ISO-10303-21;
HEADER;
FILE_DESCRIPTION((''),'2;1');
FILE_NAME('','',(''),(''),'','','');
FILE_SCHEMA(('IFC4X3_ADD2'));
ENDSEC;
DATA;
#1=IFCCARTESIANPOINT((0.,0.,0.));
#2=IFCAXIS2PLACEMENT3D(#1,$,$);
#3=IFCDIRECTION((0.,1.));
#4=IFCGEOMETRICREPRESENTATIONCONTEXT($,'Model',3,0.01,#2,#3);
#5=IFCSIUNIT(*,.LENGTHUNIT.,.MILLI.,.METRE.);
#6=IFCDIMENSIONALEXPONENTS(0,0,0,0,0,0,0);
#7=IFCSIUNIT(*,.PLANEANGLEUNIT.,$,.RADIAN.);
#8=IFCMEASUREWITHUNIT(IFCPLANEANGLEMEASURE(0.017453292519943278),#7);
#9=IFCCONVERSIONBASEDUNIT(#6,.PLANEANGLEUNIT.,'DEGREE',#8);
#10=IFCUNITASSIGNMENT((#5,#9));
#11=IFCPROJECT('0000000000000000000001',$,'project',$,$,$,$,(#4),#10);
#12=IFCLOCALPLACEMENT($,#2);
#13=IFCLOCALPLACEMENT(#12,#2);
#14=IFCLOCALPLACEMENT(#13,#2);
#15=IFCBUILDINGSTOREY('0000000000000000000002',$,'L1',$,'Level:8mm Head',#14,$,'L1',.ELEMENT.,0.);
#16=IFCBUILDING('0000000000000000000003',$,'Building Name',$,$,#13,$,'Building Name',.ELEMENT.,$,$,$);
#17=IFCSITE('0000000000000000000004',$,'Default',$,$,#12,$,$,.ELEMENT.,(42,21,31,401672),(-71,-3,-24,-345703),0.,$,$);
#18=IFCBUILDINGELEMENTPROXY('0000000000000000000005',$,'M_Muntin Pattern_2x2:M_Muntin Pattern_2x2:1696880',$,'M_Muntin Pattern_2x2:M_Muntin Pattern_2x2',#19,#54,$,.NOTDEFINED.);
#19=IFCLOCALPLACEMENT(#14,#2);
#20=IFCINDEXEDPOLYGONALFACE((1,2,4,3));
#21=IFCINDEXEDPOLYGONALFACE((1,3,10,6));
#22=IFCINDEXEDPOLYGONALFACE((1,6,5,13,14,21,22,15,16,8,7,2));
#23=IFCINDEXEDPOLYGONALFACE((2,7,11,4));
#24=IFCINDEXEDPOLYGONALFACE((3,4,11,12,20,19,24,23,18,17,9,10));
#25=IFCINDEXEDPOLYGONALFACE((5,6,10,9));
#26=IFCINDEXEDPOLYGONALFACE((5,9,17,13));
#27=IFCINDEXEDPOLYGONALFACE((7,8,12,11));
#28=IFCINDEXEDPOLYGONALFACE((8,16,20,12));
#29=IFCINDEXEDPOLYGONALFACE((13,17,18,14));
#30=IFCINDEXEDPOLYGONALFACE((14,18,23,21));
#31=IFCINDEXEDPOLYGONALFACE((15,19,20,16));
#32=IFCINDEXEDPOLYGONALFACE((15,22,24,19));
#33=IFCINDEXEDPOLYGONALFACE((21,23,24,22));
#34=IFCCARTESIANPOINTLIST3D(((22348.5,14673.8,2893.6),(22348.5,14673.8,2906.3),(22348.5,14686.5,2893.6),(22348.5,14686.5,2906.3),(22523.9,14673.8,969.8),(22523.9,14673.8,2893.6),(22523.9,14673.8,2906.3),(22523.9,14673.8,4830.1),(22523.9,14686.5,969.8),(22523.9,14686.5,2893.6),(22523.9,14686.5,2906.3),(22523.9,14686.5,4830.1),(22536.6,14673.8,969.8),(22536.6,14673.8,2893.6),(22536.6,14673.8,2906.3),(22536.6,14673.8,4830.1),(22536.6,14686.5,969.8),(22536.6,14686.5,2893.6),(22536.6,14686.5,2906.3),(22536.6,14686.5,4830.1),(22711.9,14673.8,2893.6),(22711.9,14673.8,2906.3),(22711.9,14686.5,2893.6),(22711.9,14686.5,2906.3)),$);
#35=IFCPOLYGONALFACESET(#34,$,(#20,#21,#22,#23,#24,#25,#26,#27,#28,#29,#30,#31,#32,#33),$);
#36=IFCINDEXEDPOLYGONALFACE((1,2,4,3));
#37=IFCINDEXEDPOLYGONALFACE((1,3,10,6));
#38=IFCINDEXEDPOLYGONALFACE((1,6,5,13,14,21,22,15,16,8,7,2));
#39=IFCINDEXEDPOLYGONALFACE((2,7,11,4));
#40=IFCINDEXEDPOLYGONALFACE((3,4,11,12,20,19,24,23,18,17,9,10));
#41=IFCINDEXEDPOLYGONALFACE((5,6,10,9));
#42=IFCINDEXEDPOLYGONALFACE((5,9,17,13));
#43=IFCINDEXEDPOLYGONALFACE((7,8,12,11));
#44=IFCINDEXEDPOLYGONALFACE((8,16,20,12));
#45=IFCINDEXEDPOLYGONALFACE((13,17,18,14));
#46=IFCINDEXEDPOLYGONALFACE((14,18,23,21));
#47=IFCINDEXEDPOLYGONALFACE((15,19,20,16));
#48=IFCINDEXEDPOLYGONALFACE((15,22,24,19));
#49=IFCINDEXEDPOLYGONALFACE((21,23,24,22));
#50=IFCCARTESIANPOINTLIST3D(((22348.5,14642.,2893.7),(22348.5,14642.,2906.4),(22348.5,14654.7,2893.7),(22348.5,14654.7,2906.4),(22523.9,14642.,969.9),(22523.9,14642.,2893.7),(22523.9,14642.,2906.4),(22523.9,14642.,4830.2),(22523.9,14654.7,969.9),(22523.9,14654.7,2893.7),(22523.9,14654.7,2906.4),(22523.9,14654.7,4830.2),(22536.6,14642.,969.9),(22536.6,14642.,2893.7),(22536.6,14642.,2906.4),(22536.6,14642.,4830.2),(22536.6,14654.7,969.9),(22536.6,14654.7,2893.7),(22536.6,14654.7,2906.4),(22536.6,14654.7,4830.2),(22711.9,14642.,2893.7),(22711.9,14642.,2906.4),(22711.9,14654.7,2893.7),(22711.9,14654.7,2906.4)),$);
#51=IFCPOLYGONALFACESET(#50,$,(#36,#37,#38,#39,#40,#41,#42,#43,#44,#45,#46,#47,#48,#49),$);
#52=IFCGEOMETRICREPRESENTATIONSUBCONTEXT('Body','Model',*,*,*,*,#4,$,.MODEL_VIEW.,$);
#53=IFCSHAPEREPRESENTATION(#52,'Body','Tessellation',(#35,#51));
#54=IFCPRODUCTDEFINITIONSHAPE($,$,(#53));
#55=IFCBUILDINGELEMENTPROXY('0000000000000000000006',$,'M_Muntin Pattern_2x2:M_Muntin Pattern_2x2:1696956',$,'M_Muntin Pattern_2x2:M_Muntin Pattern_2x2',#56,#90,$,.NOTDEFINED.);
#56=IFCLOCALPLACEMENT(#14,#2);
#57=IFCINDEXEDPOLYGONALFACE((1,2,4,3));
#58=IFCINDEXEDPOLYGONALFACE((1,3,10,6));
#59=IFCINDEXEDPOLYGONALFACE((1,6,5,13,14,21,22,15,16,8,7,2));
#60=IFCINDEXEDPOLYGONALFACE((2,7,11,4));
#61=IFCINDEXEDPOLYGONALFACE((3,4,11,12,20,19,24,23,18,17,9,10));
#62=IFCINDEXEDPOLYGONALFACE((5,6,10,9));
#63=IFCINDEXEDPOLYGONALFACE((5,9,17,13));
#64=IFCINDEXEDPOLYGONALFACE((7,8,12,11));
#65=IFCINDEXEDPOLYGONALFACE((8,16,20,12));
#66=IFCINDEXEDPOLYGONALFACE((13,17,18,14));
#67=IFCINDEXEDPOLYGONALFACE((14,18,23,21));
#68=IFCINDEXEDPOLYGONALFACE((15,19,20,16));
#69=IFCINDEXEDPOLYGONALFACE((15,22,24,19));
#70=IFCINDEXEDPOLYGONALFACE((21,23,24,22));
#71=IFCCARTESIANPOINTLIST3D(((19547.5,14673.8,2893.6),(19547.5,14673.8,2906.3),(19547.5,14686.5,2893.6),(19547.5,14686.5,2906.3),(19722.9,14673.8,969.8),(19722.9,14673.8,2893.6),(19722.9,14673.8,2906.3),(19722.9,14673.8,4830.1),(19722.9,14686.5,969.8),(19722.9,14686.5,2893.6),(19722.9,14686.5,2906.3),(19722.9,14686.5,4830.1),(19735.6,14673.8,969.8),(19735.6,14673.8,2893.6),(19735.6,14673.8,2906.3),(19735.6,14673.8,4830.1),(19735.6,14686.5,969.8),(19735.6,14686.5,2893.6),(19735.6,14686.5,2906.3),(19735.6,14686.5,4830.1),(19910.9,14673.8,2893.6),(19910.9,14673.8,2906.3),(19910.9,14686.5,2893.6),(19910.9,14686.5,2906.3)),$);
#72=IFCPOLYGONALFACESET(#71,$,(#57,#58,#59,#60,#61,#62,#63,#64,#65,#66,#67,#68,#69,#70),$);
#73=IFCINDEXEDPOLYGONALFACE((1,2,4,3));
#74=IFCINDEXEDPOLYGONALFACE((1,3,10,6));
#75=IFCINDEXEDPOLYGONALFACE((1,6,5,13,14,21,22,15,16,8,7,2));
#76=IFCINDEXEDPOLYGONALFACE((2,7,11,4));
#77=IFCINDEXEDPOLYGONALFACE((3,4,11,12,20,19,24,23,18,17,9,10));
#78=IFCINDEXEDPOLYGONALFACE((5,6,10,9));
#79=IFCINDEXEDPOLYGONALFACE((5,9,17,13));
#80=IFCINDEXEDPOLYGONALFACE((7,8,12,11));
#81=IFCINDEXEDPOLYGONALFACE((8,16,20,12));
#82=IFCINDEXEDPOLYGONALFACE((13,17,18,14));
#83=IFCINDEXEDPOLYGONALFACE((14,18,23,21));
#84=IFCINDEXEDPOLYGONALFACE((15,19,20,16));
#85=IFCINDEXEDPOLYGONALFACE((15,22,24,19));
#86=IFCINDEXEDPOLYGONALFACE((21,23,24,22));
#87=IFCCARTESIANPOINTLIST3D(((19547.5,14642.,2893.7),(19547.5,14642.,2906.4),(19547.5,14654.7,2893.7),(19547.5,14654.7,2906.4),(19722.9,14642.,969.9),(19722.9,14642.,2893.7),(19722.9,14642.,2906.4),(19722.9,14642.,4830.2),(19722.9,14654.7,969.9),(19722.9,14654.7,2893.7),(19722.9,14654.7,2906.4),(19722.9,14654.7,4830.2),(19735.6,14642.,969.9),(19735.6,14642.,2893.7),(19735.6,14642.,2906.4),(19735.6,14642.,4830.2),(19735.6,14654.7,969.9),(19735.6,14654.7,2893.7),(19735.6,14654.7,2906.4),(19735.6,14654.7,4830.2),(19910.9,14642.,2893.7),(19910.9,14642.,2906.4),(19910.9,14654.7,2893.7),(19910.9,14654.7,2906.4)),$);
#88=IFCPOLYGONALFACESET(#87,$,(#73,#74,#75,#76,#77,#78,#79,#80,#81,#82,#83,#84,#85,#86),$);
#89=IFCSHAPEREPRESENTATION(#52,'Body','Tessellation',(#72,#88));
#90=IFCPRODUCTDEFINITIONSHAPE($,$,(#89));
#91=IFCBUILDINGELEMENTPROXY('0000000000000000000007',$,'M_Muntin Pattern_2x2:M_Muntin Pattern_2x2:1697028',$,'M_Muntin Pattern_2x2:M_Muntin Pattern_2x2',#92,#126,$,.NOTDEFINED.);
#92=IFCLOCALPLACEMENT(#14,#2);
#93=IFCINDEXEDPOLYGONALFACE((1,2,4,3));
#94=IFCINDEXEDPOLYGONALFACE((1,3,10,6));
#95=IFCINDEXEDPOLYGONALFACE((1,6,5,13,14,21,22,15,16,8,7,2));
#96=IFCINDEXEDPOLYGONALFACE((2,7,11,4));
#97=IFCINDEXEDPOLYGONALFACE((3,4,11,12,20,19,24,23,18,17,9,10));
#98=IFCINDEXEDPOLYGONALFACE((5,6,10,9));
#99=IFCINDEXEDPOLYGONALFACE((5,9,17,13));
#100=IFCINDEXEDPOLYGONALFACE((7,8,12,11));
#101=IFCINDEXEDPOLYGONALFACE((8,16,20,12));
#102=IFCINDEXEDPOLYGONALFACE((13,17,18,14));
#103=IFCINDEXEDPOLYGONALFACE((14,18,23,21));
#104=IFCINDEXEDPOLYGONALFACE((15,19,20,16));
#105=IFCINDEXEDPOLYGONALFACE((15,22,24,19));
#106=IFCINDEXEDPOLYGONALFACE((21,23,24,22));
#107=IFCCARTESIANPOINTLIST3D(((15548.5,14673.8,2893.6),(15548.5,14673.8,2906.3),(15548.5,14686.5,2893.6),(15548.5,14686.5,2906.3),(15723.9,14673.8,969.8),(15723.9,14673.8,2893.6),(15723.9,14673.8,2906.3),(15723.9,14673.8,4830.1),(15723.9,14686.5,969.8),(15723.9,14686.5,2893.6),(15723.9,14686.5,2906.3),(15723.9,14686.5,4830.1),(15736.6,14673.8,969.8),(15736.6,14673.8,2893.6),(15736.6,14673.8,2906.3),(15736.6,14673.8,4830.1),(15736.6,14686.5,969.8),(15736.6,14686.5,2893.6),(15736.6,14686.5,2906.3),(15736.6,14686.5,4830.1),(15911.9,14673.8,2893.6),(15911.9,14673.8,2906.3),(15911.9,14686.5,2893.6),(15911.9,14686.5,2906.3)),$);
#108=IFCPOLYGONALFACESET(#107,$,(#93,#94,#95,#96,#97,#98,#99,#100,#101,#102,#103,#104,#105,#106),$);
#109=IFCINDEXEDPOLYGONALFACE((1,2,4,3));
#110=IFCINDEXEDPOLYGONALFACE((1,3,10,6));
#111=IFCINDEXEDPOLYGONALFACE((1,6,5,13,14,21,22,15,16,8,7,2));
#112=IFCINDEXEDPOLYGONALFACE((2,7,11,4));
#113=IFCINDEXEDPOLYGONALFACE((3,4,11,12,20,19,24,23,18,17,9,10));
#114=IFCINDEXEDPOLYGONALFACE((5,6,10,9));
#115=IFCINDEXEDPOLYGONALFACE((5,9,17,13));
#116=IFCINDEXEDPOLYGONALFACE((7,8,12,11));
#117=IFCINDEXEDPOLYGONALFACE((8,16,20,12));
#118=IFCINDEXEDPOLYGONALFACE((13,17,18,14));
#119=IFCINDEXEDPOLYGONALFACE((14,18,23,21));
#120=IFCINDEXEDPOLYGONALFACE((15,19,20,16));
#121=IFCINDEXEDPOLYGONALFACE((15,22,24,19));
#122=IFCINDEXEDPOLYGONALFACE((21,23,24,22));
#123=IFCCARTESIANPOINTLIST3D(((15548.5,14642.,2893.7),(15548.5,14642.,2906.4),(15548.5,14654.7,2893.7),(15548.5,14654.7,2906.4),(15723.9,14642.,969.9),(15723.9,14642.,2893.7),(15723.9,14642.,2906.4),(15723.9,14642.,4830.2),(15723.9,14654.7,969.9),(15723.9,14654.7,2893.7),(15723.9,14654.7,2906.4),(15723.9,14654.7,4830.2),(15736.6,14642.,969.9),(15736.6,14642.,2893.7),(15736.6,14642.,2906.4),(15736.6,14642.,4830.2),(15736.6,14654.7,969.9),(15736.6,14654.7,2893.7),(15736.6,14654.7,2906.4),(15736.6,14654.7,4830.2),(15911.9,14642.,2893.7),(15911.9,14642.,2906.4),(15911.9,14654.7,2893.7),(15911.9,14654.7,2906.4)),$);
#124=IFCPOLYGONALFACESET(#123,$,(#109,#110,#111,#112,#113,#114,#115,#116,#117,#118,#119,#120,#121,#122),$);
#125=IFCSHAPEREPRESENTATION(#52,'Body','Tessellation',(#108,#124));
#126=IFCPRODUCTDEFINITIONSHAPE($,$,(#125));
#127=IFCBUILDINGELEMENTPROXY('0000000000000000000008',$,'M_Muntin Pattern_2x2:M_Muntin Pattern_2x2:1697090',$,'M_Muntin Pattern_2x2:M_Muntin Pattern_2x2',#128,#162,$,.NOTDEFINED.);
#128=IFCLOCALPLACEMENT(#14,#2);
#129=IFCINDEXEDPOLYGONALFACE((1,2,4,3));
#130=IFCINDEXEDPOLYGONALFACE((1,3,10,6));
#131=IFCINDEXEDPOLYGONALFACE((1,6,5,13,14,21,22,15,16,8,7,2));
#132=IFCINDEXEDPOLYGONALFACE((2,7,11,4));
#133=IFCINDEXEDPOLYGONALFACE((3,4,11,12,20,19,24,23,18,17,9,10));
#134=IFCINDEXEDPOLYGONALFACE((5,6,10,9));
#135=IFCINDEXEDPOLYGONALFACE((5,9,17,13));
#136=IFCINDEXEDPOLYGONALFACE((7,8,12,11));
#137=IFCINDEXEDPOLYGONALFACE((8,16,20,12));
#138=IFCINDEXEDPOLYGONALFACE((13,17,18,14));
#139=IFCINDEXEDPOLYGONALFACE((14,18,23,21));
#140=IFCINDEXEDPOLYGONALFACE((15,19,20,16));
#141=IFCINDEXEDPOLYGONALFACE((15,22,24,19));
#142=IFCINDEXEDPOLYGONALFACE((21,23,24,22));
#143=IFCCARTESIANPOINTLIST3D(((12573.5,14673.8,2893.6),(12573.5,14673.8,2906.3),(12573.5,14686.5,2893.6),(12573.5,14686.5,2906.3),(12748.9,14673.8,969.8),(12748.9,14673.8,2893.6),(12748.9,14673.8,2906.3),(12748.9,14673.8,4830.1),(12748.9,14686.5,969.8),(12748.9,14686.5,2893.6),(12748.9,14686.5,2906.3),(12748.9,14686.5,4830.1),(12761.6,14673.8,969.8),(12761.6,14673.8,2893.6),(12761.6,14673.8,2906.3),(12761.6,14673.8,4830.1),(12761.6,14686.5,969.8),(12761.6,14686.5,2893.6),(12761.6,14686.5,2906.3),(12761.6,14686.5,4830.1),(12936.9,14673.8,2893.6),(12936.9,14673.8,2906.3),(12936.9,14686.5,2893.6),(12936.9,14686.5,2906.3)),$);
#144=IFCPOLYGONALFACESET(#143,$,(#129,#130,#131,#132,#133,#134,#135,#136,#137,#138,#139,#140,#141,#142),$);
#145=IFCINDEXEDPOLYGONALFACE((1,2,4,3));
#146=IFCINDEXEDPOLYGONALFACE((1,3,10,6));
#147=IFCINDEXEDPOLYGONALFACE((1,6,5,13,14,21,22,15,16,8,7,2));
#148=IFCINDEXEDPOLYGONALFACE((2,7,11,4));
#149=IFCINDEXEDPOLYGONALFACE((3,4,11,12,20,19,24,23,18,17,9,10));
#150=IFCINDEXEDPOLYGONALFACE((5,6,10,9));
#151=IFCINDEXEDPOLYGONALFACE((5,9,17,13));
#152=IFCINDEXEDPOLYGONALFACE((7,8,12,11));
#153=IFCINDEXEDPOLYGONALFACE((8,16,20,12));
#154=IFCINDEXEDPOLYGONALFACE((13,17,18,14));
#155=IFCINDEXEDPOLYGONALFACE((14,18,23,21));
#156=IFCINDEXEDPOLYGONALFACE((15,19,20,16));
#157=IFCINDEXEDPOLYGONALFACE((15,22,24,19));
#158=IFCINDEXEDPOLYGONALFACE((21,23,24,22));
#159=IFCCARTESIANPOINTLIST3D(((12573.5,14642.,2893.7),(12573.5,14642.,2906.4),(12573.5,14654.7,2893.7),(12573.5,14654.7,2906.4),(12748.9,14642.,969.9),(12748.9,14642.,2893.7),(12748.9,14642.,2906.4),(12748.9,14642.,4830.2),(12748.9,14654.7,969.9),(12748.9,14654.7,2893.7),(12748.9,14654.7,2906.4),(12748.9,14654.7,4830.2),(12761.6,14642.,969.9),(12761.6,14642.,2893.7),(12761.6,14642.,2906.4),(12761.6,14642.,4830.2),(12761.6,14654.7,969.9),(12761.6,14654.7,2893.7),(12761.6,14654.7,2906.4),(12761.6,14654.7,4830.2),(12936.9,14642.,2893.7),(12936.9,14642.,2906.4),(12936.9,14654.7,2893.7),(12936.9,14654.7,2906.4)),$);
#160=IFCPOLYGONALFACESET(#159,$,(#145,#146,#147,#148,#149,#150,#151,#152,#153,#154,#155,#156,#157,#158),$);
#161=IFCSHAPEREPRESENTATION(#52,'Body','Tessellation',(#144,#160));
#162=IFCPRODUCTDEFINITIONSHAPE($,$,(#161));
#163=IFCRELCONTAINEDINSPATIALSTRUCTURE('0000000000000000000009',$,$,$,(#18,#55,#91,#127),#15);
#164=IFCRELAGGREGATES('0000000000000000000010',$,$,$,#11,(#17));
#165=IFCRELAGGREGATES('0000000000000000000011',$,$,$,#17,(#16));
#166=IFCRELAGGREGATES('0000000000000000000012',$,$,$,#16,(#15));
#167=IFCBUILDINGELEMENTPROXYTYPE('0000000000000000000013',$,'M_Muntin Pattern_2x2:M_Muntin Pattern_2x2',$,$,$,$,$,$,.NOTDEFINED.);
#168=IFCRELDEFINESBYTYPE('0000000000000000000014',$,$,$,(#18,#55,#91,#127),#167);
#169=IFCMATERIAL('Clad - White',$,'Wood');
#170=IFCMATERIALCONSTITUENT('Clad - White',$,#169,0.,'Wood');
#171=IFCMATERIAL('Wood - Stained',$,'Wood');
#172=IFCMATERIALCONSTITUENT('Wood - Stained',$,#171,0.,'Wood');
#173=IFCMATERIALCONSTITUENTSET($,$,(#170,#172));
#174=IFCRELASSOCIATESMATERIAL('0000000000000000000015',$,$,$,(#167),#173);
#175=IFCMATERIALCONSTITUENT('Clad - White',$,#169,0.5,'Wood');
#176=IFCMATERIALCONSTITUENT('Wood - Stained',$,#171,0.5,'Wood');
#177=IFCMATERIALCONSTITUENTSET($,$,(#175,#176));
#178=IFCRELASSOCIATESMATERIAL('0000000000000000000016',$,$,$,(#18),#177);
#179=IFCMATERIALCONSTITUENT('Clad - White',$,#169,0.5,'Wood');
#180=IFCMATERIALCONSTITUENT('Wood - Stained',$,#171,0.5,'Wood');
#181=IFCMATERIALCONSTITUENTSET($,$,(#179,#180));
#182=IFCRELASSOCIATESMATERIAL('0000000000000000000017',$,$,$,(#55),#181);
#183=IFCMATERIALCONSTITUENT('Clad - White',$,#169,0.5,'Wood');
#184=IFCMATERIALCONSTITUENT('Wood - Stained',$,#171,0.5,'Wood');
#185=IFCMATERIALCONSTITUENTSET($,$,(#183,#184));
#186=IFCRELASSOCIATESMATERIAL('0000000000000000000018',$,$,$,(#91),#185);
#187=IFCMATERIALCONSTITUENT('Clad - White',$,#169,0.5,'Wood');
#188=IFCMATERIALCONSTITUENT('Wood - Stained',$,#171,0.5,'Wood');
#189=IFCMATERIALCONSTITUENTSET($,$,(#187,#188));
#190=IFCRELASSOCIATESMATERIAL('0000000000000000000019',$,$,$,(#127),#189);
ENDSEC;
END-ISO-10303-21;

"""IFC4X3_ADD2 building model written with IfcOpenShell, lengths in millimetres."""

from ifc_helpers import new_model, entity, si_unit, converted_unit, direction, frame, origin, place, context, subcontext, project, spatial, polyline, outline, extrude, source, transform, mapped, material, constituent, constituent_set, type_object, type_shapes, element, save


model = new_model("IFC4X3_ADD2")

# Units and contexts
model_context = context("Model", 3, precision=0.01, world=origin(), true_north=direction((0.0, 1.0)))
body_context = subcontext(model_context, "Body", "Model", "MODEL_VIEW")
ifc_project = project(units=[si_unit("LENGTHUNIT", "METRE", prefix="MILLI"), converted_unit("PLANEANGLEUNIT", "DEGREE", entity("IfcPlaneAngleMeasure", 0.017453292519943278), si_unit("PLANEANGLEUNIT", "RADIAN"), dimensions=[0, 0, 0, 0, 0, 0, 0])], contexts=[model_context])

# Site, building, storey
site_placement = place(None, origin())
site = spatial("IfcSite", under=ifc_project, at=site_placement, Name="Default", CompositionType="ELEMENT", RefLatitude=(42, 21, 31, 401672), RefLongitude=(-71, -3, -24, -345703), RefElevation=0.0)
building_placement = place(site_placement, origin())
building = spatial("IfcBuilding", under=site, at=building_placement, Name="Building Name", LongName="Building Name", CompositionType="ELEMENT")
storey_placement = place(building_placement, origin())
storey = spatial("IfcBuildingStorey", under=building, at=storey_placement, Name="L1", ObjectType="Level:8mm Head", LongName="L1", CompositionType="ELEMENT", Elevation=0.0)

# Building element proxies
ifc_material_1 = material(Name="Clad - White", Category="Wood")
ifc_material_2 = material(Name="Wood - Stained", Category="Wood")
ifc_constituent_1 = constituent(ifc_material_1, Name="Clad - White", Category="Wood", fraction=0.5)
ifc_constituent_2 = constituent(ifc_material_2, Name="Wood - Stained", Category="Wood", fraction=0.5)
ifc_constituent_set_1 = constituent_set(constituents=[ifc_constituent_1, ifc_constituent_2])
ifc_constituent_3 = constituent(ifc_material_1, Name="Clad - White", Category="Wood", fraction=0.0)
ifc_constituent_4 = constituent(ifc_material_2, Name="Wood - Stained", Category="Wood", fraction=0.0)
ifc_constituent_set_2 = constituent_set(constituents=[ifc_constituent_3, ifc_constituent_4])
building_element_proxy_type_1 = type_object("IfcBuildingElementProxyType", Name="M_Muntin Pattern_2x2:M_Muntin Pattern_2x2", PredefinedType="NOTDEFINED", material=ifc_constituent_set_2)
shared_shape_1 = source(origin(), body_context, "Body", "SweptSolid", [
    extrude(outline(polyline([(6.4, -6.4), (1930.1, -6.4), (1930.1, 6.3), (6.4, 6.3), (6.4, 181.7), (-6.3, 181.7), (-6.3, 6.3), (-1930.2, 6.3), (-1930.2, -6.4), (-6.3, -6.4), (-6.3, -181.7), (6.4, -181.7), (6.4, -6.4)])), frame((0.0, -22.2, 1930.1), z_axis=(0.0, 1.0, 0.0), x_axis=(0.0, 0.0, 1.0)), (0.0, 0.0, 1.0), 12.7),
    extrude(outline(polyline([(6.4, -6.4), (1930.2, -6.4), (1930.2, 6.3), (6.4, 6.3), (6.4, 181.7), (-6.3, 181.7), (-6.3, 6.3), (-1930.2, 6.3), (-1930.2, -6.4), (-6.3, -6.4), (-6.3, -181.7), (6.4, -181.7), (6.4, -6.4)])), frame((0.0, 9.5, 1930.2), z_axis=(0.0, 1.0, 0.0), x_axis=(0.0, 0.0, 1.0)), (0.0, 0.0, 1.0), 12.7),
])
type_shapes(building_element_proxy_type_1, [shared_shape_1])
proxy_1_placement = place(storey_placement, frame((22530.2, 14664.3, 969.9), z_axis=(0.0, 0.0, 1.0), x_axis=(-1.0, 0.0, 0.0)))
element("IfcBuildingElementProxy", 1, at=proxy_1_placement, inside=storey, type_object=building_element_proxy_type_1, material=ifc_constituent_set_1, Name="M_Muntin Pattern_2x2:M_Muntin Pattern_2x2:1696880", ObjectType="M_Muntin Pattern_2x2:M_Muntin Pattern_2x2", PredefinedType="NOTDEFINED", context=body_context, shape_type="MappedRepresentation", body=[
    mapped(shared_shape_1, transform((0.0, 0.0, 0.0), scale=1.0)),
])
ifc_constituent_5 = constituent(ifc_material_1, Name="Clad - White", Category="Wood", fraction=0.5)
ifc_constituent_6 = constituent(ifc_material_2, Name="Wood - Stained", Category="Wood", fraction=0.5)
ifc_constituent_set_3 = constituent_set(constituents=[ifc_constituent_5, ifc_constituent_6])
proxy_2_placement = place(storey_placement, frame((19729.2, 14664.3, 969.9), z_axis=(0.0, 0.0, 1.0), x_axis=(-1.0, 0.0, 0.0)))
element("IfcBuildingElementProxy", 2, at=proxy_2_placement, inside=storey, type_object=building_element_proxy_type_1, material=ifc_constituent_set_3, Name="M_Muntin Pattern_2x2:M_Muntin Pattern_2x2:1696956", ObjectType="M_Muntin Pattern_2x2:M_Muntin Pattern_2x2", PredefinedType="NOTDEFINED", context=body_context, shape_type="MappedRepresentation", body=[
    mapped(shared_shape_1, transform((0.0, 0.0, 0.0), scale=1.0)),
])
ifc_constituent_7 = constituent(ifc_material_1, Name="Clad - White", Category="Wood", fraction=0.5)
ifc_constituent_8 = constituent(ifc_material_2, Name="Wood - Stained", Category="Wood", fraction=0.5)
ifc_constituent_set_4 = constituent_set(constituents=[ifc_constituent_7, ifc_constituent_8])
proxy_3_placement = place(storey_placement, frame((15730.2, 14664.3, 969.9), z_axis=(0.0, 0.0, 1.0), x_axis=(-1.0, 0.0, 0.0)))
element("IfcBuildingElementProxy", 3, at=proxy_3_placement, inside=storey, type_object=building_element_proxy_type_1, material=ifc_constituent_set_4, Name="M_Muntin Pattern_2x2:M_Muntin Pattern_2x2:1697028", ObjectType="M_Muntin Pattern_2x2:M_Muntin Pattern_2x2", PredefinedType="NOTDEFINED", context=body_context, shape_type="MappedRepresentation", body=[
    mapped(shared_shape_1, transform((0.0, 0.0, 0.0), scale=1.0)),
])
ifc_constituent_9 = constituent(ifc_material_1, Name="Clad - White", Category="Wood", fraction=0.5)
ifc_constituent_10 = constituent(ifc_material_2, Name="Wood - Stained", Category="Wood", fraction=0.5)
ifc_constituent_set_5 = constituent_set(constituents=[ifc_constituent_9, ifc_constituent_10])
proxy_4_placement = place(storey_placement, frame((12755.2, 14664.3, 969.9), z_axis=(0.0, 0.0, 1.0), x_axis=(-1.0, 0.0, 0.0)))
element("IfcBuildingElementProxy", 4, at=proxy_4_placement, inside=storey, type_object=building_element_proxy_type_1, material=ifc_constituent_set_5, Name="M_Muntin Pattern_2x2:M_Muntin Pattern_2x2:1697090", ObjectType="M_Muntin Pattern_2x2:M_Muntin Pattern_2x2", PredefinedType="NOTDEFINED", context=body_context, shape_type="MappedRepresentation", body=[
    mapped(shared_shape_1, transform((0.0, 0.0, 0.0), scale=1.0)),
])

save(model, "model.ifc")
